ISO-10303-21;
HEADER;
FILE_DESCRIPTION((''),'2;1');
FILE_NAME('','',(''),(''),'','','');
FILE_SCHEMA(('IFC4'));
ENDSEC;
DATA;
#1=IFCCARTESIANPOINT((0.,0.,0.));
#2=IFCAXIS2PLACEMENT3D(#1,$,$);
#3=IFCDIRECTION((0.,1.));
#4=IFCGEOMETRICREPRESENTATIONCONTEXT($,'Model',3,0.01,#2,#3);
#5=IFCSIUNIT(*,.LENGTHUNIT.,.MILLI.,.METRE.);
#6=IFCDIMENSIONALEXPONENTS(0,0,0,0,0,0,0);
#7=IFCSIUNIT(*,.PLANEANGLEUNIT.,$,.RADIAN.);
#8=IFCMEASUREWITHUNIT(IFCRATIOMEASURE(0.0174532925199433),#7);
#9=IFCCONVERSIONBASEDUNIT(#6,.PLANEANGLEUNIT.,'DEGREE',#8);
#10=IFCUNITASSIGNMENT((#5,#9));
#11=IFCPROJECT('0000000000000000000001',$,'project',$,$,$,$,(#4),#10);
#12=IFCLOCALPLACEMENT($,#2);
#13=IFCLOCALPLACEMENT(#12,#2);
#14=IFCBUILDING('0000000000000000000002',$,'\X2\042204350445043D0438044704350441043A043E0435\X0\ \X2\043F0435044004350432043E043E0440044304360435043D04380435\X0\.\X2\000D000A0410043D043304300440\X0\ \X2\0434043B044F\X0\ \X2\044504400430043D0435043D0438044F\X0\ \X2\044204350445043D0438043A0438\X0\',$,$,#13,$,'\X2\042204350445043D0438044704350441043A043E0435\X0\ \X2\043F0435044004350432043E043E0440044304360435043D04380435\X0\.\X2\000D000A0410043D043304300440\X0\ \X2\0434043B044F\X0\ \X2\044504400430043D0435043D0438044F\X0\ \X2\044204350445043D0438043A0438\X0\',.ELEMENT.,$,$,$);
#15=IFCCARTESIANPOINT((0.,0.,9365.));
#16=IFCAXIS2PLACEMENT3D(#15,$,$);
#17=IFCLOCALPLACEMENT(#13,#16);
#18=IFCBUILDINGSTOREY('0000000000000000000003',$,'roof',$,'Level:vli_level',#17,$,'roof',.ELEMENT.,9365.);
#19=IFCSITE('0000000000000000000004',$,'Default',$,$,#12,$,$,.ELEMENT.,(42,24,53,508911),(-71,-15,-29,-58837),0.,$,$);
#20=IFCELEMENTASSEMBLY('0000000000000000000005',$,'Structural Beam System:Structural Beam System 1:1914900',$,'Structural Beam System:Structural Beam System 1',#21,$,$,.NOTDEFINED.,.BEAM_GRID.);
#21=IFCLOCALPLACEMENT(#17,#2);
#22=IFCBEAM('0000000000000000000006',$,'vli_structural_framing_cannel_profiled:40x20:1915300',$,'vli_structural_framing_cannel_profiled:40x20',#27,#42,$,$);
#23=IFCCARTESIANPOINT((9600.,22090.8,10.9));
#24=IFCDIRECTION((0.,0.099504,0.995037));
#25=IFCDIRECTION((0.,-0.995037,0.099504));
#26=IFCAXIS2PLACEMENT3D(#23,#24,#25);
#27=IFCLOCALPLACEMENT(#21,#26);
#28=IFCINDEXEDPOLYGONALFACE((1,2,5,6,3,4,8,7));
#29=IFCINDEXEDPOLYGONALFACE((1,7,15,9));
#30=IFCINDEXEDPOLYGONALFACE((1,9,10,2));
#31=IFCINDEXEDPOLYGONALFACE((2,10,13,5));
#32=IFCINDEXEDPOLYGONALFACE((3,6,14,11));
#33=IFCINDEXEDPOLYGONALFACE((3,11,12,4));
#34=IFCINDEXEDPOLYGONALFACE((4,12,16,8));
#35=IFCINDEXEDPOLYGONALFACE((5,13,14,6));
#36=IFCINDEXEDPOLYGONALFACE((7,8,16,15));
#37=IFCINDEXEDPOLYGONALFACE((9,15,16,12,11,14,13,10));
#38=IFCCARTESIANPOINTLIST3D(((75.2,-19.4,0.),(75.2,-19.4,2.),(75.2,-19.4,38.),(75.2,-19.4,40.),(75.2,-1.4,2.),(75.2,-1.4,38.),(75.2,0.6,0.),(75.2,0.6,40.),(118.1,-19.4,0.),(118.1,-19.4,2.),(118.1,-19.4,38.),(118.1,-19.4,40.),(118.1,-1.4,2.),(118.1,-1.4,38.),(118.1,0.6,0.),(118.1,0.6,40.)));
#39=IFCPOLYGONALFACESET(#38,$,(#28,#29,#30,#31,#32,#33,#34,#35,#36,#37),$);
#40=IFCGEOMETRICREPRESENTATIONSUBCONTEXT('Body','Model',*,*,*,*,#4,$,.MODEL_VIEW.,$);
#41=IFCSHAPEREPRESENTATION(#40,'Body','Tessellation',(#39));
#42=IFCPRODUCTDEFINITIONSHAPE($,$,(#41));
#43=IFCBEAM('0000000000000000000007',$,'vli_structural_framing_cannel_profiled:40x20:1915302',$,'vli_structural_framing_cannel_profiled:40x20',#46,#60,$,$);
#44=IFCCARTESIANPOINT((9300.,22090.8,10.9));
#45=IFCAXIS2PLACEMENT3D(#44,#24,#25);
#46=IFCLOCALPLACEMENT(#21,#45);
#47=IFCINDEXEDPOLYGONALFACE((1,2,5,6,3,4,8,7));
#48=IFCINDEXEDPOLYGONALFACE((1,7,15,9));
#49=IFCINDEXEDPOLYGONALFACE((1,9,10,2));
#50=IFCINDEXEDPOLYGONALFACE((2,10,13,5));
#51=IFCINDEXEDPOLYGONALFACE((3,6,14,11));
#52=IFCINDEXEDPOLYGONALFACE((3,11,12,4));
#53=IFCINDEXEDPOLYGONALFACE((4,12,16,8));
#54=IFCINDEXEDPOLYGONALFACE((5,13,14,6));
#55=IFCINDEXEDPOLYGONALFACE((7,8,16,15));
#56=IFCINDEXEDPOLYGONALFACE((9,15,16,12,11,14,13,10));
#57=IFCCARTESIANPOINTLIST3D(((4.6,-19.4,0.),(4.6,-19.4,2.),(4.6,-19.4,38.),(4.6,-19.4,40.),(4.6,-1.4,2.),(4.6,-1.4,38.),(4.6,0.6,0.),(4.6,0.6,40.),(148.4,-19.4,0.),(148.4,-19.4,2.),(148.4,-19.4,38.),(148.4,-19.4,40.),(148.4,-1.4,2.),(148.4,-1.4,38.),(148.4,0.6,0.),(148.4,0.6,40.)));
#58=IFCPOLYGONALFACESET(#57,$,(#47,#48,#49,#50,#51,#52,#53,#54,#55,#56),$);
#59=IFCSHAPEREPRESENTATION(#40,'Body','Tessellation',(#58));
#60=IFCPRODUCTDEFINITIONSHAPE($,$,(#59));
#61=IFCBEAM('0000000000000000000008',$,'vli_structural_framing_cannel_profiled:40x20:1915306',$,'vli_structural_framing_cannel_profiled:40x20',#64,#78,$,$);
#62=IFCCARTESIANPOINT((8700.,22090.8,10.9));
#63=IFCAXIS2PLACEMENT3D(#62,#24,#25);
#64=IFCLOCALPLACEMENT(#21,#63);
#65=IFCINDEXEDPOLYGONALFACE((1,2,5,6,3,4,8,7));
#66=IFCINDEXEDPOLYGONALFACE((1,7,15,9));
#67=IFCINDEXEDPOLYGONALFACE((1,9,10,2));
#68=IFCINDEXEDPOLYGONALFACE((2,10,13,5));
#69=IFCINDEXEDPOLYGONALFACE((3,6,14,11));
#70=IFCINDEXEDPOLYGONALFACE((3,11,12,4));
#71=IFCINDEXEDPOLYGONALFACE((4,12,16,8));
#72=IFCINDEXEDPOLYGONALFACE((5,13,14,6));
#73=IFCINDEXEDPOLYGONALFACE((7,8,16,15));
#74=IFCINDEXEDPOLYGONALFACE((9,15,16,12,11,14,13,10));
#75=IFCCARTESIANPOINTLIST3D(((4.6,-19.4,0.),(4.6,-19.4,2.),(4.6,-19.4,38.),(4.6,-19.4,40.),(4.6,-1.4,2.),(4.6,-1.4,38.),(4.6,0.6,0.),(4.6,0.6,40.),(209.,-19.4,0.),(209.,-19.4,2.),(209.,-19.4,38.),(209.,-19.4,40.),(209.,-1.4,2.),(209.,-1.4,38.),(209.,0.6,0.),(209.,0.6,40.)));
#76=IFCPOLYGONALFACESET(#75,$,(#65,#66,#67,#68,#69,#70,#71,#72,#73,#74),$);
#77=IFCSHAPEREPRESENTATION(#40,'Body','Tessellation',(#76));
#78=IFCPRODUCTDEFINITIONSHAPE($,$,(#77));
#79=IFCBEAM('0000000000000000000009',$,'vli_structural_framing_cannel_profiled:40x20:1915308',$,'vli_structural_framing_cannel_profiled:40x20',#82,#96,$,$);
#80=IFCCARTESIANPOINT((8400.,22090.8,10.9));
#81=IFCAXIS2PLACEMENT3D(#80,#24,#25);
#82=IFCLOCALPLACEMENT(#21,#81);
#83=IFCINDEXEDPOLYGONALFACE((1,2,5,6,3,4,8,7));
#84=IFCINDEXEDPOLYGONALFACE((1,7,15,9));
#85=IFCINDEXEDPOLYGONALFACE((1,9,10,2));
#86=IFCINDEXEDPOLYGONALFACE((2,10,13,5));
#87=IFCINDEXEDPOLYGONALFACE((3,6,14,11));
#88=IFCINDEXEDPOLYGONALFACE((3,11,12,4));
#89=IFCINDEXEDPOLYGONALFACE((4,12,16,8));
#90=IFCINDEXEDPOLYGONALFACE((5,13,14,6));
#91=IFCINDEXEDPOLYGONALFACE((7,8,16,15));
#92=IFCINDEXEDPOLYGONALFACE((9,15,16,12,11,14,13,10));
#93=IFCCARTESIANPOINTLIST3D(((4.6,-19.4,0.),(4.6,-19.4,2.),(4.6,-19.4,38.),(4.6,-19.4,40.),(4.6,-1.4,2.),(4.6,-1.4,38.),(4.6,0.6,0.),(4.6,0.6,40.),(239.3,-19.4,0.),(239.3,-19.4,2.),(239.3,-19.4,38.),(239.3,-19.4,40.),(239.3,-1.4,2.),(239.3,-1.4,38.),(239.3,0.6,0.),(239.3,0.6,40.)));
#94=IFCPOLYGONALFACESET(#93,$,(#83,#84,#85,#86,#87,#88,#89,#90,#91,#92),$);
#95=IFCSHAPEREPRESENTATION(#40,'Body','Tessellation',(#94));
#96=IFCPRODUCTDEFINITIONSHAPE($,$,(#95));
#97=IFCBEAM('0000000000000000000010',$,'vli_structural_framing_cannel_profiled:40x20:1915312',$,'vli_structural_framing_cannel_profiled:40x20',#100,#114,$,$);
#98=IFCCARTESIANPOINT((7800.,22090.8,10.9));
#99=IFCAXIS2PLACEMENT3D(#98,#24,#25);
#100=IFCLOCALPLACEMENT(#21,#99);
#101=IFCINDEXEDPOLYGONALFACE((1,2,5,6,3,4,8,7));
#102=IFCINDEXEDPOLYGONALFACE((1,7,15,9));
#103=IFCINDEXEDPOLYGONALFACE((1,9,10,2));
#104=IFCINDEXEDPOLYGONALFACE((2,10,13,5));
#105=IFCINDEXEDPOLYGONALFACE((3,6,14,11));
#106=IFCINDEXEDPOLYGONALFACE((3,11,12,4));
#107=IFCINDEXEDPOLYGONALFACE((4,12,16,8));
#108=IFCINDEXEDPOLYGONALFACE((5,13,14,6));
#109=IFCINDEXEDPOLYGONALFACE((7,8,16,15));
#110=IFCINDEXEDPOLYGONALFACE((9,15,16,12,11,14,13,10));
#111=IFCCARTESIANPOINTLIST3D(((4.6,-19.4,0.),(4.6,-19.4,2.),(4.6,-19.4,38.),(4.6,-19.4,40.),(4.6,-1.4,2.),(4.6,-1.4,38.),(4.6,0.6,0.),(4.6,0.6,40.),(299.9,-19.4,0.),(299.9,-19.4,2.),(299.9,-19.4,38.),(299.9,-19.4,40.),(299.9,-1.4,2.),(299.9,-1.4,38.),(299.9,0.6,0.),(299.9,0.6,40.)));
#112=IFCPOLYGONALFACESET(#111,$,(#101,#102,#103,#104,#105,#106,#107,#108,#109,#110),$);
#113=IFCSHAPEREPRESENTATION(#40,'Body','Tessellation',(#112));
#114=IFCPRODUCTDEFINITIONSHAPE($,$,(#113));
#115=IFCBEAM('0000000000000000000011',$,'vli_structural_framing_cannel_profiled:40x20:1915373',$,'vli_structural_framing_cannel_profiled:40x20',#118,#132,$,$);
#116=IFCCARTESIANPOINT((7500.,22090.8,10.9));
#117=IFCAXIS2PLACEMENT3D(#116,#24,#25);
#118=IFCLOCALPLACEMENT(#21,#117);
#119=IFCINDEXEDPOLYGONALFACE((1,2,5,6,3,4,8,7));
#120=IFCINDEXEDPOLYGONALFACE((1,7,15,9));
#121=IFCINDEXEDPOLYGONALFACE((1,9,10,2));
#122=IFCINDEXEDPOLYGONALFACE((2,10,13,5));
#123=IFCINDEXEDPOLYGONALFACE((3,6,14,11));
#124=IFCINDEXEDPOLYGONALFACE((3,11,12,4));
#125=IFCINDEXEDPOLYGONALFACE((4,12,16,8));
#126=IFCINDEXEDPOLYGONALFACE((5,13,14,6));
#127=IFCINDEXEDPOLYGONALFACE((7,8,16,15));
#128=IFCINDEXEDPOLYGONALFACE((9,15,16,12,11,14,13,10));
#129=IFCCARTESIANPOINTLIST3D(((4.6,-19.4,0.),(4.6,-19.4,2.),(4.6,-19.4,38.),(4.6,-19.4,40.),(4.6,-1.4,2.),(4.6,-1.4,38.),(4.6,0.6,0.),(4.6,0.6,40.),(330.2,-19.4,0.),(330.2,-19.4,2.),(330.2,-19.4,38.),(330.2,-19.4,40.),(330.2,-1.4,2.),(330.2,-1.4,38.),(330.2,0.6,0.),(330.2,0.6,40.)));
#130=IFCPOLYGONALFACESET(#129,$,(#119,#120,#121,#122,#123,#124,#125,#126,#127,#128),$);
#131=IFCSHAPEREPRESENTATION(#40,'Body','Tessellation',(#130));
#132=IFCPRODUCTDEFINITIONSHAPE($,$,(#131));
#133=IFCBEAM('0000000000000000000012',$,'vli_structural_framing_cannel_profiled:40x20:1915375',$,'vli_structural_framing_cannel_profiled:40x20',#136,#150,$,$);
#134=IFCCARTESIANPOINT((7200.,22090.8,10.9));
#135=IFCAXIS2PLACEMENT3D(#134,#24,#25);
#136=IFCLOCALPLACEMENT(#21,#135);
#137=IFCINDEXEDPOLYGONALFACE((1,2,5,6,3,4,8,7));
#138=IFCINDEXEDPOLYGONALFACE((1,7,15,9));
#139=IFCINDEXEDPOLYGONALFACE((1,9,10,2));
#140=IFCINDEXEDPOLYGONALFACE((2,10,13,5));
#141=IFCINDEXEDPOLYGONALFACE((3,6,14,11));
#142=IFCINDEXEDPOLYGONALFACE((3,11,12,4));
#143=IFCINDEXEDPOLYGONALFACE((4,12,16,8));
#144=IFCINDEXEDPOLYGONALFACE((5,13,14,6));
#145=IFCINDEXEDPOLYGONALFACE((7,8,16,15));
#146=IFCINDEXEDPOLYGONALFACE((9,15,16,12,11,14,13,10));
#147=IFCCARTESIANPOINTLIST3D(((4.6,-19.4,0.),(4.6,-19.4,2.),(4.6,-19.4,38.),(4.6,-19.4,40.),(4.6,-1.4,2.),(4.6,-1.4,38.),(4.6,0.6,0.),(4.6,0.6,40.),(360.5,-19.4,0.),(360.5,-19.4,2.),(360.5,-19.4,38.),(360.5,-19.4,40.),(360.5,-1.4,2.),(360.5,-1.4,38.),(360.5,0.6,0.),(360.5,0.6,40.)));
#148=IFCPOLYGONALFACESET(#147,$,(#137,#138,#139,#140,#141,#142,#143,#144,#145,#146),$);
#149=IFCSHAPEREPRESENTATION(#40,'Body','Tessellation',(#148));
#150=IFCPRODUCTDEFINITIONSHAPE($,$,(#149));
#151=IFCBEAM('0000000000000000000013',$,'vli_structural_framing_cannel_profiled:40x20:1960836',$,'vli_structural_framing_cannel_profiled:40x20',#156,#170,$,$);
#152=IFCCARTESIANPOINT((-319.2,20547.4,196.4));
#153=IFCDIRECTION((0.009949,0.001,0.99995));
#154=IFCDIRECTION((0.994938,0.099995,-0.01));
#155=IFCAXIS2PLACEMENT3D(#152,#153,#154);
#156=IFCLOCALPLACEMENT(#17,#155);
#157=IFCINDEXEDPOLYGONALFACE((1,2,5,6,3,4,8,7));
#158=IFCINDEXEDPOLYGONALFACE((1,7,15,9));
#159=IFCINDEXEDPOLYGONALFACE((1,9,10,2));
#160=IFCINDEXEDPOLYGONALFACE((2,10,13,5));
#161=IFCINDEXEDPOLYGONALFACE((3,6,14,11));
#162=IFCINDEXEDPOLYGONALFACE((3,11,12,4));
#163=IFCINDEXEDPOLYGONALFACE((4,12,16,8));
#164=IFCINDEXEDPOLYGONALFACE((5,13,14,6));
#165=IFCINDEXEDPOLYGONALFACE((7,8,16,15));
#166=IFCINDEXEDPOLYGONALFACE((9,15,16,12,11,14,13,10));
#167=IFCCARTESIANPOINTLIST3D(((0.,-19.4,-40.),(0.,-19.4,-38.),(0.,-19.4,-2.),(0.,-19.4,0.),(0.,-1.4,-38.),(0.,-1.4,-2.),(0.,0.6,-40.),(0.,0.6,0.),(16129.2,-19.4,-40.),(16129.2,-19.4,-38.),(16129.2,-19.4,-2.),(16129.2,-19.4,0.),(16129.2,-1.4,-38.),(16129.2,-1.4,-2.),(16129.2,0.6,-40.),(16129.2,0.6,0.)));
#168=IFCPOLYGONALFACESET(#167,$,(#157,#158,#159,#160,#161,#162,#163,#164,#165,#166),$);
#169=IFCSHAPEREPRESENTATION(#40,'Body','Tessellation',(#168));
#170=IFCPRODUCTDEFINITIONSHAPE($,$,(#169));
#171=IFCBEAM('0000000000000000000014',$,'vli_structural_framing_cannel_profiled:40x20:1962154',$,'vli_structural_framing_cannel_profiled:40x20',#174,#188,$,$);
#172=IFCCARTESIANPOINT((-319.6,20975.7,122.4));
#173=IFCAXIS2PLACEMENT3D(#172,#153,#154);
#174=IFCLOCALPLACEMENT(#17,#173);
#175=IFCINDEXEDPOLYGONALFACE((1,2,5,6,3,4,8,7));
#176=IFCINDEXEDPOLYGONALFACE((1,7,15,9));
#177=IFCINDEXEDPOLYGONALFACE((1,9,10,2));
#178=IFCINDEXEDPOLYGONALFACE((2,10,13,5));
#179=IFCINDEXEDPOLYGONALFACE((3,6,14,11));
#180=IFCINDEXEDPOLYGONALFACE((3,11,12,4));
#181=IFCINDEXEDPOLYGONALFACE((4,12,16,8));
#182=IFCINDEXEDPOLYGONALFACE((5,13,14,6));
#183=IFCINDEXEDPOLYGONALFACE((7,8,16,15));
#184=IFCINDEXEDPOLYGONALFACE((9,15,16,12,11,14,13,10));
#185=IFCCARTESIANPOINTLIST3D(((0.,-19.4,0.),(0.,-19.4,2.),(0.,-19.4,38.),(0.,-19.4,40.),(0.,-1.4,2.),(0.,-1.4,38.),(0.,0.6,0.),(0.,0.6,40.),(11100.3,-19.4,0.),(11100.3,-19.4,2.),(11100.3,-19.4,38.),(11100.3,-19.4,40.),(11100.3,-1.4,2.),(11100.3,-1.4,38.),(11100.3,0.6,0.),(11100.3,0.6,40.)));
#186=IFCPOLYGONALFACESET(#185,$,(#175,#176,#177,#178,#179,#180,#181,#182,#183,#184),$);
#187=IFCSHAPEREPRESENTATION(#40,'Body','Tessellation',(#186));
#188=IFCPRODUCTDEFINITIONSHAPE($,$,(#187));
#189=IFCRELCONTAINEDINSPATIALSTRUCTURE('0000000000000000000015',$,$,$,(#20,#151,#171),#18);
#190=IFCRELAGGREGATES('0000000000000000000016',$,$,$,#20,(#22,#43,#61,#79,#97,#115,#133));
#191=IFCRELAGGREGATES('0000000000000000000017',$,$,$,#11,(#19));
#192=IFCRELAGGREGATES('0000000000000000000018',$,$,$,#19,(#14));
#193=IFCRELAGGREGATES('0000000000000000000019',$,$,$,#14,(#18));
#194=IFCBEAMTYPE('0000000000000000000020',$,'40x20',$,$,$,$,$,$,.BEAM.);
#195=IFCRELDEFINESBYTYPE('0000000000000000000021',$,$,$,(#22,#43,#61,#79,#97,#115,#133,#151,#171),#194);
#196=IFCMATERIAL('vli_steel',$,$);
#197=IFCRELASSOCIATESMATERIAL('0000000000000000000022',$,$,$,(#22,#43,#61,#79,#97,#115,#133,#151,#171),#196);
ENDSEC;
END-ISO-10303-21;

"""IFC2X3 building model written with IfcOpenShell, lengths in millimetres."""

from ifc_helpers import new_model, entity, si_unit, converted_unit, direction, frame, origin, place, context, subcontext, project, spatial, polyline, outline, extrude, material, type_object, element, aggregate, save


model = new_model("IFC2X3")

# Units and contexts
model_context = context("Model", 3, precision=0.01, world=origin(), true_north=direction((0.0, 1.0)))
body_context = subcontext(model_context, "Body", "Model", "MODEL_VIEW")
ifc_project = project(units=[si_unit("LENGTHUNIT", "METRE", prefix="MILLI"), converted_unit("PLANEANGLEUNIT", "DEGREE", entity("IfcRatioMeasure", 0.0174532925199433), si_unit("PLANEANGLEUNIT", "RADIAN"), dimensions=[0, 0, 0, 0, 0, 0, 0])], contexts=[model_context])

# Site, building, storey
site_placement = place(None, origin())
site = spatial("IfcSite", under=ifc_project, at=site_placement, Name="Default", CompositionType="ELEMENT", RefLatitude=(42, 24, 53, 508911), RefLongitude=(-71, -15, -29, -58837), RefElevation=0.0)
building_placement = place(site_placement, origin())
building = spatial("IfcBuilding", under=site, at=building_placement, Name="Техническое перевооружение.\r\nАнгар для хранения техники", LongName="Техническое перевооружение.\r\nАнгар для хранения техники", CompositionType="ELEMENT")
storey_placement = place(building_placement, frame((0.0, 0.0, 9365.0)))
storey = spatial("IfcBuildingStorey", under=building, at=storey_placement, Name="roof", ObjectType="Level:vli_level", LongName="roof", CompositionType="ELEMENT", Elevation=9365.0)

# Element assembly, beams
assembly_placement = place(storey_placement, origin())
assembly = element("IfcElementAssembly", 1, at=assembly_placement, inside=storey, Name="Structural Beam System:Structural Beam System 1:1914900", ObjectType="Structural Beam System:Structural Beam System 1", AssemblyPlace="NOTDEFINED", PredefinedType="BEAM_GRID")
ifc_material = material(Name="vli_steel")
beam_type = type_object("IfcBeamType", Name="40x20", PredefinedType="BEAM")
beam_1_placement = place(assembly_placement, frame((9600.0, 22090.8, 10.9), z_axis=(0.0, 0.099504, 0.995037), x_axis=(0.0, -0.995037, 0.099504)))
beam_1 = element("IfcBeam", 2, at=beam_1_placement, type_object=beam_type, material=ifc_material, Name="vli_structural_framing_cannel_profiled:40x20:1915300", ObjectType="vli_structural_framing_cannel_profiled:40x20", context=body_context, shape_type="SweptSolid", body=[
    extrude(outline(polyline([(-20.0, -9.5), (-18.0, -9.5), (-18.0, 8.5), (18.0, 8.5), (18.0, -9.5), (20.0, -9.5), (20.0, 10.5), (-20.0, 10.5), (-20.0, -9.5)])), frame((75.2, -9.9, 20.0), z_axis=(1.0, 0.0, 0.0), x_axis=(0.0, 0.0, -1.0)), (0.0, 0.0, 1.0), 42.9),
])
beam_2_placement = place(assembly_placement, frame((9300.0, 22090.8, 10.9), z_axis=(0.0, 0.099504, 0.995037), x_axis=(0.0, -0.995037, 0.099504)))
beam_2 = element("IfcBeam", 3, at=beam_2_placement, type_object=beam_type, material=ifc_material, Name="vli_structural_framing_cannel_profiled:40x20:1915302", ObjectType="vli_structural_framing_cannel_profiled:40x20", context=body_context, shape_type="SweptSolid", body=[
    extrude(outline(polyline([(-20.0, -9.5), (-18.0, -9.5), (-18.0, 8.5), (18.0, 8.5), (18.0, -9.5), (20.0, -9.5), (20.0, 10.5), (-20.0, 10.5), (-20.0, -9.5)])), frame((4.6, -9.9, 20.0), z_axis=(1.0, 0.0, 0.0), x_axis=(0.0, 0.0, -1.0)), (0.0, 0.0, 1.0), 143.8),
])
beam_3_placement = place(assembly_placement, frame((8700.0, 22090.8, 10.9), z_axis=(0.0, 0.099504, 0.995037), x_axis=(0.0, -0.995037, 0.099504)))
beam_3 = element("IfcBeam", 4, at=beam_3_placement, type_object=beam_type, material=ifc_material, Name="vli_structural_framing_cannel_profiled:40x20:1915306", ObjectType="vli_structural_framing_cannel_profiled:40x20", context=body_context, shape_type="SweptSolid", body=[
    extrude(outline(polyline([(-20.0, -9.5), (-18.0, -9.5), (-18.0, 8.5), (18.0, 8.5), (18.0, -9.5), (20.0, -9.5), (20.0, 10.5), (-20.0, 10.5), (-20.0, -9.5)])), frame((4.6, -9.9, 20.0), z_axis=(1.0, 0.0, 0.0), x_axis=(0.0, 0.0, -1.0)), (0.0, 0.0, 1.0), 204.4),
])
beam_4_placement = place(assembly_placement, frame((8400.0, 22090.8, 10.9), z_axis=(0.0, 0.099504, 0.995037), x_axis=(0.0, -0.995037, 0.099504)))
beam_4 = element("IfcBeam", 5, at=beam_4_placement, type_object=beam_type, material=ifc_material, Name="vli_structural_framing_cannel_profiled:40x20:1915308", ObjectType="vli_structural_framing_cannel_profiled:40x20", context=body_context, shape_type="SweptSolid", body=[
    extrude(outline(polyline([(-20.0, -9.5), (-18.0, -9.5), (-18.0, 8.5), (18.0, 8.5), (18.0, -9.5), (20.0, -9.5), (20.0, 10.5), (-20.0, 10.5), (-20.0, -9.5)])), frame((4.6, -9.9, 20.0), z_axis=(1.0, 0.0, 0.0), x_axis=(0.0, 0.0, -1.0)), (0.0, 0.0, 1.0), 234.7),
])
beam_5_placement = place(assembly_placement, frame((7800.0, 22090.8, 10.9), z_axis=(0.0, 0.099504, 0.995037), x_axis=(0.0, -0.995037, 0.099504)))
beam_5 = element("IfcBeam", 6, at=beam_5_placement, type_object=beam_type, material=ifc_material, Name="vli_structural_framing_cannel_profiled:40x20:1915312", ObjectType="vli_structural_framing_cannel_profiled:40x20", context=body_context, shape_type="SweptSolid", body=[
    extrude(outline(polyline([(-20.0, -9.5), (-18.0, -9.5), (-18.0, 8.5), (18.0, 8.5), (18.0, -9.5), (20.0, -9.5), (20.0, 10.5), (-20.0, 10.5), (-20.0, -9.5)])), frame((4.6, -9.9, 20.0), z_axis=(1.0, 0.0, 0.0), x_axis=(0.0, 0.0, -1.0)), (0.0, 0.0, 1.0), 295.3),
])
beam_6_placement = place(assembly_placement, frame((7500.0, 22090.8, 10.9), z_axis=(0.0, 0.099504, 0.995037), x_axis=(0.0, -0.995037, 0.099504)))
beam_6 = element("IfcBeam", 7, at=beam_6_placement, type_object=beam_type, material=ifc_material, Name="vli_structural_framing_cannel_profiled:40x20:1915373", ObjectType="vli_structural_framing_cannel_profiled:40x20", context=body_context, shape_type="SweptSolid", body=[
    extrude(outline(polyline([(-20.0, -9.5), (-18.0, -9.5), (-18.0, 8.5), (18.0, 8.5), (18.0, -9.5), (20.0, -9.5), (20.0, 10.5), (-20.0, 10.5), (-20.0, -9.5)])), frame((4.6, -9.9, 20.0), z_axis=(1.0, 0.0, 0.0), x_axis=(0.0, 0.0, -1.0)), (0.0, 0.0, 1.0), 325.6),
])
beam_7_placement = place(assembly_placement, frame((7200.0, 22090.8, 10.9), z_axis=(0.0, 0.099504, 0.995037), x_axis=(0.0, -0.995037, 0.099504)))
beam_7 = element("IfcBeam", 8, at=beam_7_placement, type_object=beam_type, material=ifc_material, Name="vli_structural_framing_cannel_profiled:40x20:1915375", ObjectType="vli_structural_framing_cannel_profiled:40x20", context=body_context, shape_type="SweptSolid", body=[
    extrude(outline(polyline([(-20.0, -9.5), (-18.0, -9.5), (-18.0, 8.5), (18.0, 8.5), (18.0, -9.5), (20.0, -9.5), (20.0, 10.5), (-20.0, 10.5), (-20.0, -9.5)])), frame((4.6, -9.9, 20.0), z_axis=(1.0, 0.0, 0.0), x_axis=(0.0, 0.0, -1.0)), (0.0, 0.0, 1.0), 355.9),
])
aggregate(assembly, [beam_1, beam_2, beam_3, beam_4, beam_5, beam_6, beam_7])

# Beams
beam_8_placement = place(storey_placement, frame((-319.2, 20547.4, 196.4), z_axis=(0.009949, 0.001, 0.99995), x_axis=(0.994938, 0.099995, -0.01)))
element("IfcBeam", 9, at=beam_8_placement, inside=storey, type_object=beam_type, material=ifc_material, Name="vli_structural_framing_cannel_profiled:40x20:1960836", ObjectType="vli_structural_framing_cannel_profiled:40x20", context=body_context, shape_type="SweptSolid", body=[
    extrude(outline(polyline([(-20.0, -9.5), (-18.0, -9.5), (-18.0, 8.5), (18.0, 8.5), (18.0, -9.5), (20.0, -9.5), (20.0, 10.5), (-20.0, 10.5), (-20.0, -9.5)])), frame((0.0, -9.9, -20.0), z_axis=(1.0, 0.0, 0.0), x_axis=(0.0, 0.0, -1.0)), (0.0, 0.0, 1.0), 16129.2),
])
beam_9_placement = place(storey_placement, frame((-319.6, 20975.7, 122.4), z_axis=(0.009949, 0.001, 0.99995), x_axis=(0.994938, 0.099995, -0.01)))
element("IfcBeam", 10, at=beam_9_placement, inside=storey, type_object=beam_type, material=ifc_material, Name="vli_structural_framing_cannel_profiled:40x20:1962154", ObjectType="vli_structural_framing_cannel_profiled:40x20", context=body_context, shape_type="SweptSolid", body=[
    extrude(outline(polyline([(-20.0, -9.5), (-18.0, -9.5), (-18.0, 8.5), (18.0, 8.5), (18.0, -9.5), (20.0, -9.5), (20.0, 10.5), (-20.0, 10.5), (-20.0, -9.5)])), frame((0.0, -9.9, 20.0), z_axis=(1.0, 0.0, 0.0), x_axis=(0.0, 0.0, -1.0)), (0.0, 0.0, 1.0), 11100.3),
])

save(model, "model.ifc")
